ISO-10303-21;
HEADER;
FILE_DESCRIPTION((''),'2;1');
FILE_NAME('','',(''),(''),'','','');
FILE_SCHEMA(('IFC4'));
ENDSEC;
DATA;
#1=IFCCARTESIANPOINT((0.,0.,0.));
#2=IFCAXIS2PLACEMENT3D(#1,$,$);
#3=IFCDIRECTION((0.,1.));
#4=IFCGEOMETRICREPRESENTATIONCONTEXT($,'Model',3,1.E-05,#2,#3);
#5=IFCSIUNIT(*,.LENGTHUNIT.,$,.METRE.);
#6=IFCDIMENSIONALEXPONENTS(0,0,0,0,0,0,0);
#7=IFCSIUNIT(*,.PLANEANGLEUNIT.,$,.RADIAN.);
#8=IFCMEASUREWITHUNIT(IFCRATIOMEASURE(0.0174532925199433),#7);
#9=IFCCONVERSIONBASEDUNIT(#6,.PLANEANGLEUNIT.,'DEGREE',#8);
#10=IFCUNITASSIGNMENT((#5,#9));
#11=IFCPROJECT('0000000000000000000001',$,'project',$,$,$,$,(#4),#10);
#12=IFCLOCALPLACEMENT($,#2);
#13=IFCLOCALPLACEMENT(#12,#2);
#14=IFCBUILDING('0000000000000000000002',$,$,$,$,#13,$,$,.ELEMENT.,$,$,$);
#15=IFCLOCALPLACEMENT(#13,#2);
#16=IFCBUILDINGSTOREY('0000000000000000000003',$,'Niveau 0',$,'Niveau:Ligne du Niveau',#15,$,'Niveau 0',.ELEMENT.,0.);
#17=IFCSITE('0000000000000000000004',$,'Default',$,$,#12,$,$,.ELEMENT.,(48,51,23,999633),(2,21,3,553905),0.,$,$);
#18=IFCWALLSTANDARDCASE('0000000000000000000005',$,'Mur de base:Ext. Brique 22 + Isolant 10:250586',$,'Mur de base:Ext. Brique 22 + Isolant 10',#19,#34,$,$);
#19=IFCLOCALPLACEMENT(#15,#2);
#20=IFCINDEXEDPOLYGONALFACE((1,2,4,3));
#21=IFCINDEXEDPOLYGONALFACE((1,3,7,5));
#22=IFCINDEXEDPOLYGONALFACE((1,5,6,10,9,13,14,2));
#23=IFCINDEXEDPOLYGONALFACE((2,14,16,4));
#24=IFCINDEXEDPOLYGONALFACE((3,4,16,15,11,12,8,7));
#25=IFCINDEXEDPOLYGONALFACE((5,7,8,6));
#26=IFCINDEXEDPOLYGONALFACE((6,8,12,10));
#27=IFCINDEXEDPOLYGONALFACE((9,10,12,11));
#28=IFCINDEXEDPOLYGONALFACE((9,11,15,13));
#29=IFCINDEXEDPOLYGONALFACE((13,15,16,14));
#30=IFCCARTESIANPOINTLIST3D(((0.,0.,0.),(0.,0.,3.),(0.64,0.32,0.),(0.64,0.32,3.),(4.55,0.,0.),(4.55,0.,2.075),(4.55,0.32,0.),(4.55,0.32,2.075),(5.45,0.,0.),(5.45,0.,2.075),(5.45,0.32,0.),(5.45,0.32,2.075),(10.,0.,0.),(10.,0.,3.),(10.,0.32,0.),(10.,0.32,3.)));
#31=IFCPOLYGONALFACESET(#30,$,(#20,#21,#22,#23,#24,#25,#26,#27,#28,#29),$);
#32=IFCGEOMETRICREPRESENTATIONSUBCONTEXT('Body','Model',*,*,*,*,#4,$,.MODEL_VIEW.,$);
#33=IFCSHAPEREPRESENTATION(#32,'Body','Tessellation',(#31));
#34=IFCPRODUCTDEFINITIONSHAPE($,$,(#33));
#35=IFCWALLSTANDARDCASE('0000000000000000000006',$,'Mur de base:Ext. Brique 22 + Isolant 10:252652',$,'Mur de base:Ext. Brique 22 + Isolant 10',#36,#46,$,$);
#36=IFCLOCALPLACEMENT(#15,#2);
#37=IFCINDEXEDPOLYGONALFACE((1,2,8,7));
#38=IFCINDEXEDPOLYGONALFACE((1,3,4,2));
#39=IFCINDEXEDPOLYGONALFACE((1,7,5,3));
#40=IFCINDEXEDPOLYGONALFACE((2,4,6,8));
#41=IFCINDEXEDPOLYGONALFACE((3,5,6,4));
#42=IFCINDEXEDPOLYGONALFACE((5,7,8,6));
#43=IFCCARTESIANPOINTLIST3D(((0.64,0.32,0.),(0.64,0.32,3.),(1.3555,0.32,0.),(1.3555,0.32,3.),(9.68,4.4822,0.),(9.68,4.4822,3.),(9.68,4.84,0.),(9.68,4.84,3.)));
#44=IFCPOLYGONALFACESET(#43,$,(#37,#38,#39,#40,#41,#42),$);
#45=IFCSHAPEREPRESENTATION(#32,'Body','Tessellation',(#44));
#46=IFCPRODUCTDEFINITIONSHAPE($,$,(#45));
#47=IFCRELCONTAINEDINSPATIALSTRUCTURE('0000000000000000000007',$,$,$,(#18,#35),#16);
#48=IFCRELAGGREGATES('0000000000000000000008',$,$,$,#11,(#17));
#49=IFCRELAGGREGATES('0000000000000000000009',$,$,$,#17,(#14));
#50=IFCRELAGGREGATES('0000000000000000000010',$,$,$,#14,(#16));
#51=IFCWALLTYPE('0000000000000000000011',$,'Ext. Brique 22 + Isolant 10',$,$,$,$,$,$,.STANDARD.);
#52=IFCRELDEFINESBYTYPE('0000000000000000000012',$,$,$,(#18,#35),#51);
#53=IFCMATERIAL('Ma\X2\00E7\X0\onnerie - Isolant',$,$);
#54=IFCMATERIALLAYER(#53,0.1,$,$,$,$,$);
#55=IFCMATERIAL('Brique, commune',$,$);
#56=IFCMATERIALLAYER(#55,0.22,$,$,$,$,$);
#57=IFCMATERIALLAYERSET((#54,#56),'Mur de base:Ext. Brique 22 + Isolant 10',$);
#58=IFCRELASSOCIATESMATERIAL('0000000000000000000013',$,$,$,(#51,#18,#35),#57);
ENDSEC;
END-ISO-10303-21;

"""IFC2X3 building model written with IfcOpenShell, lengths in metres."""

from ifc_helpers import new_model, entity, si_unit, converted_unit, direction, frame, frame_2d, origin, place, context, subcontext, project, spatial, polyline, rectangle, outline, extrude, material, layer, layer_set, layer_usage, type_object, element, save


model = new_model("IFC2X3")

# Units and contexts
model_context = context("Model", 3, precision=1e-05, world=origin(), true_north=direction((0.0, 1.0)))
body_context = subcontext(model_context, "Body", "Model", "MODEL_VIEW")
ifc_project = project(units=[si_unit("LENGTHUNIT", "METRE"), converted_unit("PLANEANGLEUNIT", "DEGREE", entity("IfcRatioMeasure", 0.0174532925199433), si_unit("PLANEANGLEUNIT", "RADIAN"), dimensions=[0, 0, 0, 0, 0, 0, 0])], contexts=[model_context])

# Site, building, storey
site_placement = place(None, origin())
site = spatial("IfcSite", under=ifc_project, at=site_placement, Name="Default", CompositionType="ELEMENT", RefLatitude=(48, 51, 23, 999633), RefLongitude=(2, 21, 3, 553905), RefElevation=0.0)
building_placement = place(site_placement, origin())
building = spatial("IfcBuilding", under=site, at=building_placement, CompositionType="ELEMENT")
storey_placement = place(building_placement, origin())
storey = spatial("IfcBuildingStorey", under=building, at=storey_placement, Name="Niveau 0", ObjectType="Niveau:Ligne du Niveau", LongName="Niveau 0", CompositionType="ELEMENT", Elevation=0.0)

# Wall, opening
ifc_material_1 = material(Name="Maçonnerie - Isolant")
ifc_layer_1 = layer(ifc_material_1, 0.1)
ifc_material_2 = material(Name="Brique, commune")
ifc_layer_2 = layer(ifc_material_2, 0.22)
ifc_layer_set_1 = layer_set([ifc_layer_1, ifc_layer_2], Name="Mur de base:Ext. Brique 22 + Isolant 10")
ifc_layer_usage_1 = layer_usage(ifc_layer_set_1, "AXIS2", "NEGATIVE", 0.16)
wall_type = type_object("IfcWallType", Name="Ext. Brique 22 + Isolant 10", PredefinedType="STANDARD", material=ifc_layer_set_1)
wall_1_placement = place(storey_placement, frame((10.0, 0.16, 0.0), z_axis=(0.0, 0.0, 1.0), x_axis=(-1.0, 0.0, 0.0)))
wall_1 = element("IfcWallStandardCase", 1, at=wall_1_placement, inside=storey, type_object=wall_type, material=ifc_layer_usage_1, Name="Mur de base:Ext. Brique 22 + Isolant 10:250586", ObjectType="Mur de base:Ext. Brique 22 + Isolant 10", context=body_context, shape_type="SweptSolid", body=[
    extrude(outline(polyline([(0.0, -0.16), (0.32, -0.16), (8.6445, -0.16), (9.36, -0.16), (10.0, 0.16), (0.0, 0.16), (0.0, -0.16)])), origin(), (0.0, 0.0, 1.0), 3.0),
])
opening_placement = place(wall_1_placement, frame((5.45, 0.16, 0.0)))
element("IfcOpeningElement", 2, at=opening_placement, cuts=wall_1, ObjectType="Opening", context=body_context, shape_type="SweptSolid", body=[
    extrude(rectangle(XDim=2.075, YDim=0.9, at=frame_2d((1.0375, 0.45), x_axis=(1.0, 0.0))), frame((0.0, 0.0, 0.0), z_axis=(0.0, -1.0, 0.0), x_axis=(0.0, 0.0, 1.0)), (0.0, 0.0, 1.0), 0.32),
])

# Wall
ifc_layer_usage_2 = layer_usage(ifc_layer_set_1, "AXIS2", "NEGATIVE", 0.16)
wall_2_placement = place(storey_placement, frame((0.7116, 0.1769, 0.0), z_axis=(0.0, 0.0, 1.0), x_axis=(0.894427, 0.447214, 0.0)))
element("IfcWallStandardCase", 3, at=wall_2_placement, inside=storey, type_object=wall_type, material=ifc_layer_usage_2, Name="Mur de base:Ext. Brique 22 + Isolant 10:252652", ObjectType="Mur de base:Ext. Brique 22 + Isolant 10", context=body_context, shape_type="SweptSolid", body=[
    extrude(outline(polyline([(9.947, -0.16), (10.107, 0.16), (0.0, 0.16), (0.64, -0.16), (9.947, -0.16)])), origin(), (0.0, 0.0, 1.0), 3.0),
])

save(model, "model.ifc")
